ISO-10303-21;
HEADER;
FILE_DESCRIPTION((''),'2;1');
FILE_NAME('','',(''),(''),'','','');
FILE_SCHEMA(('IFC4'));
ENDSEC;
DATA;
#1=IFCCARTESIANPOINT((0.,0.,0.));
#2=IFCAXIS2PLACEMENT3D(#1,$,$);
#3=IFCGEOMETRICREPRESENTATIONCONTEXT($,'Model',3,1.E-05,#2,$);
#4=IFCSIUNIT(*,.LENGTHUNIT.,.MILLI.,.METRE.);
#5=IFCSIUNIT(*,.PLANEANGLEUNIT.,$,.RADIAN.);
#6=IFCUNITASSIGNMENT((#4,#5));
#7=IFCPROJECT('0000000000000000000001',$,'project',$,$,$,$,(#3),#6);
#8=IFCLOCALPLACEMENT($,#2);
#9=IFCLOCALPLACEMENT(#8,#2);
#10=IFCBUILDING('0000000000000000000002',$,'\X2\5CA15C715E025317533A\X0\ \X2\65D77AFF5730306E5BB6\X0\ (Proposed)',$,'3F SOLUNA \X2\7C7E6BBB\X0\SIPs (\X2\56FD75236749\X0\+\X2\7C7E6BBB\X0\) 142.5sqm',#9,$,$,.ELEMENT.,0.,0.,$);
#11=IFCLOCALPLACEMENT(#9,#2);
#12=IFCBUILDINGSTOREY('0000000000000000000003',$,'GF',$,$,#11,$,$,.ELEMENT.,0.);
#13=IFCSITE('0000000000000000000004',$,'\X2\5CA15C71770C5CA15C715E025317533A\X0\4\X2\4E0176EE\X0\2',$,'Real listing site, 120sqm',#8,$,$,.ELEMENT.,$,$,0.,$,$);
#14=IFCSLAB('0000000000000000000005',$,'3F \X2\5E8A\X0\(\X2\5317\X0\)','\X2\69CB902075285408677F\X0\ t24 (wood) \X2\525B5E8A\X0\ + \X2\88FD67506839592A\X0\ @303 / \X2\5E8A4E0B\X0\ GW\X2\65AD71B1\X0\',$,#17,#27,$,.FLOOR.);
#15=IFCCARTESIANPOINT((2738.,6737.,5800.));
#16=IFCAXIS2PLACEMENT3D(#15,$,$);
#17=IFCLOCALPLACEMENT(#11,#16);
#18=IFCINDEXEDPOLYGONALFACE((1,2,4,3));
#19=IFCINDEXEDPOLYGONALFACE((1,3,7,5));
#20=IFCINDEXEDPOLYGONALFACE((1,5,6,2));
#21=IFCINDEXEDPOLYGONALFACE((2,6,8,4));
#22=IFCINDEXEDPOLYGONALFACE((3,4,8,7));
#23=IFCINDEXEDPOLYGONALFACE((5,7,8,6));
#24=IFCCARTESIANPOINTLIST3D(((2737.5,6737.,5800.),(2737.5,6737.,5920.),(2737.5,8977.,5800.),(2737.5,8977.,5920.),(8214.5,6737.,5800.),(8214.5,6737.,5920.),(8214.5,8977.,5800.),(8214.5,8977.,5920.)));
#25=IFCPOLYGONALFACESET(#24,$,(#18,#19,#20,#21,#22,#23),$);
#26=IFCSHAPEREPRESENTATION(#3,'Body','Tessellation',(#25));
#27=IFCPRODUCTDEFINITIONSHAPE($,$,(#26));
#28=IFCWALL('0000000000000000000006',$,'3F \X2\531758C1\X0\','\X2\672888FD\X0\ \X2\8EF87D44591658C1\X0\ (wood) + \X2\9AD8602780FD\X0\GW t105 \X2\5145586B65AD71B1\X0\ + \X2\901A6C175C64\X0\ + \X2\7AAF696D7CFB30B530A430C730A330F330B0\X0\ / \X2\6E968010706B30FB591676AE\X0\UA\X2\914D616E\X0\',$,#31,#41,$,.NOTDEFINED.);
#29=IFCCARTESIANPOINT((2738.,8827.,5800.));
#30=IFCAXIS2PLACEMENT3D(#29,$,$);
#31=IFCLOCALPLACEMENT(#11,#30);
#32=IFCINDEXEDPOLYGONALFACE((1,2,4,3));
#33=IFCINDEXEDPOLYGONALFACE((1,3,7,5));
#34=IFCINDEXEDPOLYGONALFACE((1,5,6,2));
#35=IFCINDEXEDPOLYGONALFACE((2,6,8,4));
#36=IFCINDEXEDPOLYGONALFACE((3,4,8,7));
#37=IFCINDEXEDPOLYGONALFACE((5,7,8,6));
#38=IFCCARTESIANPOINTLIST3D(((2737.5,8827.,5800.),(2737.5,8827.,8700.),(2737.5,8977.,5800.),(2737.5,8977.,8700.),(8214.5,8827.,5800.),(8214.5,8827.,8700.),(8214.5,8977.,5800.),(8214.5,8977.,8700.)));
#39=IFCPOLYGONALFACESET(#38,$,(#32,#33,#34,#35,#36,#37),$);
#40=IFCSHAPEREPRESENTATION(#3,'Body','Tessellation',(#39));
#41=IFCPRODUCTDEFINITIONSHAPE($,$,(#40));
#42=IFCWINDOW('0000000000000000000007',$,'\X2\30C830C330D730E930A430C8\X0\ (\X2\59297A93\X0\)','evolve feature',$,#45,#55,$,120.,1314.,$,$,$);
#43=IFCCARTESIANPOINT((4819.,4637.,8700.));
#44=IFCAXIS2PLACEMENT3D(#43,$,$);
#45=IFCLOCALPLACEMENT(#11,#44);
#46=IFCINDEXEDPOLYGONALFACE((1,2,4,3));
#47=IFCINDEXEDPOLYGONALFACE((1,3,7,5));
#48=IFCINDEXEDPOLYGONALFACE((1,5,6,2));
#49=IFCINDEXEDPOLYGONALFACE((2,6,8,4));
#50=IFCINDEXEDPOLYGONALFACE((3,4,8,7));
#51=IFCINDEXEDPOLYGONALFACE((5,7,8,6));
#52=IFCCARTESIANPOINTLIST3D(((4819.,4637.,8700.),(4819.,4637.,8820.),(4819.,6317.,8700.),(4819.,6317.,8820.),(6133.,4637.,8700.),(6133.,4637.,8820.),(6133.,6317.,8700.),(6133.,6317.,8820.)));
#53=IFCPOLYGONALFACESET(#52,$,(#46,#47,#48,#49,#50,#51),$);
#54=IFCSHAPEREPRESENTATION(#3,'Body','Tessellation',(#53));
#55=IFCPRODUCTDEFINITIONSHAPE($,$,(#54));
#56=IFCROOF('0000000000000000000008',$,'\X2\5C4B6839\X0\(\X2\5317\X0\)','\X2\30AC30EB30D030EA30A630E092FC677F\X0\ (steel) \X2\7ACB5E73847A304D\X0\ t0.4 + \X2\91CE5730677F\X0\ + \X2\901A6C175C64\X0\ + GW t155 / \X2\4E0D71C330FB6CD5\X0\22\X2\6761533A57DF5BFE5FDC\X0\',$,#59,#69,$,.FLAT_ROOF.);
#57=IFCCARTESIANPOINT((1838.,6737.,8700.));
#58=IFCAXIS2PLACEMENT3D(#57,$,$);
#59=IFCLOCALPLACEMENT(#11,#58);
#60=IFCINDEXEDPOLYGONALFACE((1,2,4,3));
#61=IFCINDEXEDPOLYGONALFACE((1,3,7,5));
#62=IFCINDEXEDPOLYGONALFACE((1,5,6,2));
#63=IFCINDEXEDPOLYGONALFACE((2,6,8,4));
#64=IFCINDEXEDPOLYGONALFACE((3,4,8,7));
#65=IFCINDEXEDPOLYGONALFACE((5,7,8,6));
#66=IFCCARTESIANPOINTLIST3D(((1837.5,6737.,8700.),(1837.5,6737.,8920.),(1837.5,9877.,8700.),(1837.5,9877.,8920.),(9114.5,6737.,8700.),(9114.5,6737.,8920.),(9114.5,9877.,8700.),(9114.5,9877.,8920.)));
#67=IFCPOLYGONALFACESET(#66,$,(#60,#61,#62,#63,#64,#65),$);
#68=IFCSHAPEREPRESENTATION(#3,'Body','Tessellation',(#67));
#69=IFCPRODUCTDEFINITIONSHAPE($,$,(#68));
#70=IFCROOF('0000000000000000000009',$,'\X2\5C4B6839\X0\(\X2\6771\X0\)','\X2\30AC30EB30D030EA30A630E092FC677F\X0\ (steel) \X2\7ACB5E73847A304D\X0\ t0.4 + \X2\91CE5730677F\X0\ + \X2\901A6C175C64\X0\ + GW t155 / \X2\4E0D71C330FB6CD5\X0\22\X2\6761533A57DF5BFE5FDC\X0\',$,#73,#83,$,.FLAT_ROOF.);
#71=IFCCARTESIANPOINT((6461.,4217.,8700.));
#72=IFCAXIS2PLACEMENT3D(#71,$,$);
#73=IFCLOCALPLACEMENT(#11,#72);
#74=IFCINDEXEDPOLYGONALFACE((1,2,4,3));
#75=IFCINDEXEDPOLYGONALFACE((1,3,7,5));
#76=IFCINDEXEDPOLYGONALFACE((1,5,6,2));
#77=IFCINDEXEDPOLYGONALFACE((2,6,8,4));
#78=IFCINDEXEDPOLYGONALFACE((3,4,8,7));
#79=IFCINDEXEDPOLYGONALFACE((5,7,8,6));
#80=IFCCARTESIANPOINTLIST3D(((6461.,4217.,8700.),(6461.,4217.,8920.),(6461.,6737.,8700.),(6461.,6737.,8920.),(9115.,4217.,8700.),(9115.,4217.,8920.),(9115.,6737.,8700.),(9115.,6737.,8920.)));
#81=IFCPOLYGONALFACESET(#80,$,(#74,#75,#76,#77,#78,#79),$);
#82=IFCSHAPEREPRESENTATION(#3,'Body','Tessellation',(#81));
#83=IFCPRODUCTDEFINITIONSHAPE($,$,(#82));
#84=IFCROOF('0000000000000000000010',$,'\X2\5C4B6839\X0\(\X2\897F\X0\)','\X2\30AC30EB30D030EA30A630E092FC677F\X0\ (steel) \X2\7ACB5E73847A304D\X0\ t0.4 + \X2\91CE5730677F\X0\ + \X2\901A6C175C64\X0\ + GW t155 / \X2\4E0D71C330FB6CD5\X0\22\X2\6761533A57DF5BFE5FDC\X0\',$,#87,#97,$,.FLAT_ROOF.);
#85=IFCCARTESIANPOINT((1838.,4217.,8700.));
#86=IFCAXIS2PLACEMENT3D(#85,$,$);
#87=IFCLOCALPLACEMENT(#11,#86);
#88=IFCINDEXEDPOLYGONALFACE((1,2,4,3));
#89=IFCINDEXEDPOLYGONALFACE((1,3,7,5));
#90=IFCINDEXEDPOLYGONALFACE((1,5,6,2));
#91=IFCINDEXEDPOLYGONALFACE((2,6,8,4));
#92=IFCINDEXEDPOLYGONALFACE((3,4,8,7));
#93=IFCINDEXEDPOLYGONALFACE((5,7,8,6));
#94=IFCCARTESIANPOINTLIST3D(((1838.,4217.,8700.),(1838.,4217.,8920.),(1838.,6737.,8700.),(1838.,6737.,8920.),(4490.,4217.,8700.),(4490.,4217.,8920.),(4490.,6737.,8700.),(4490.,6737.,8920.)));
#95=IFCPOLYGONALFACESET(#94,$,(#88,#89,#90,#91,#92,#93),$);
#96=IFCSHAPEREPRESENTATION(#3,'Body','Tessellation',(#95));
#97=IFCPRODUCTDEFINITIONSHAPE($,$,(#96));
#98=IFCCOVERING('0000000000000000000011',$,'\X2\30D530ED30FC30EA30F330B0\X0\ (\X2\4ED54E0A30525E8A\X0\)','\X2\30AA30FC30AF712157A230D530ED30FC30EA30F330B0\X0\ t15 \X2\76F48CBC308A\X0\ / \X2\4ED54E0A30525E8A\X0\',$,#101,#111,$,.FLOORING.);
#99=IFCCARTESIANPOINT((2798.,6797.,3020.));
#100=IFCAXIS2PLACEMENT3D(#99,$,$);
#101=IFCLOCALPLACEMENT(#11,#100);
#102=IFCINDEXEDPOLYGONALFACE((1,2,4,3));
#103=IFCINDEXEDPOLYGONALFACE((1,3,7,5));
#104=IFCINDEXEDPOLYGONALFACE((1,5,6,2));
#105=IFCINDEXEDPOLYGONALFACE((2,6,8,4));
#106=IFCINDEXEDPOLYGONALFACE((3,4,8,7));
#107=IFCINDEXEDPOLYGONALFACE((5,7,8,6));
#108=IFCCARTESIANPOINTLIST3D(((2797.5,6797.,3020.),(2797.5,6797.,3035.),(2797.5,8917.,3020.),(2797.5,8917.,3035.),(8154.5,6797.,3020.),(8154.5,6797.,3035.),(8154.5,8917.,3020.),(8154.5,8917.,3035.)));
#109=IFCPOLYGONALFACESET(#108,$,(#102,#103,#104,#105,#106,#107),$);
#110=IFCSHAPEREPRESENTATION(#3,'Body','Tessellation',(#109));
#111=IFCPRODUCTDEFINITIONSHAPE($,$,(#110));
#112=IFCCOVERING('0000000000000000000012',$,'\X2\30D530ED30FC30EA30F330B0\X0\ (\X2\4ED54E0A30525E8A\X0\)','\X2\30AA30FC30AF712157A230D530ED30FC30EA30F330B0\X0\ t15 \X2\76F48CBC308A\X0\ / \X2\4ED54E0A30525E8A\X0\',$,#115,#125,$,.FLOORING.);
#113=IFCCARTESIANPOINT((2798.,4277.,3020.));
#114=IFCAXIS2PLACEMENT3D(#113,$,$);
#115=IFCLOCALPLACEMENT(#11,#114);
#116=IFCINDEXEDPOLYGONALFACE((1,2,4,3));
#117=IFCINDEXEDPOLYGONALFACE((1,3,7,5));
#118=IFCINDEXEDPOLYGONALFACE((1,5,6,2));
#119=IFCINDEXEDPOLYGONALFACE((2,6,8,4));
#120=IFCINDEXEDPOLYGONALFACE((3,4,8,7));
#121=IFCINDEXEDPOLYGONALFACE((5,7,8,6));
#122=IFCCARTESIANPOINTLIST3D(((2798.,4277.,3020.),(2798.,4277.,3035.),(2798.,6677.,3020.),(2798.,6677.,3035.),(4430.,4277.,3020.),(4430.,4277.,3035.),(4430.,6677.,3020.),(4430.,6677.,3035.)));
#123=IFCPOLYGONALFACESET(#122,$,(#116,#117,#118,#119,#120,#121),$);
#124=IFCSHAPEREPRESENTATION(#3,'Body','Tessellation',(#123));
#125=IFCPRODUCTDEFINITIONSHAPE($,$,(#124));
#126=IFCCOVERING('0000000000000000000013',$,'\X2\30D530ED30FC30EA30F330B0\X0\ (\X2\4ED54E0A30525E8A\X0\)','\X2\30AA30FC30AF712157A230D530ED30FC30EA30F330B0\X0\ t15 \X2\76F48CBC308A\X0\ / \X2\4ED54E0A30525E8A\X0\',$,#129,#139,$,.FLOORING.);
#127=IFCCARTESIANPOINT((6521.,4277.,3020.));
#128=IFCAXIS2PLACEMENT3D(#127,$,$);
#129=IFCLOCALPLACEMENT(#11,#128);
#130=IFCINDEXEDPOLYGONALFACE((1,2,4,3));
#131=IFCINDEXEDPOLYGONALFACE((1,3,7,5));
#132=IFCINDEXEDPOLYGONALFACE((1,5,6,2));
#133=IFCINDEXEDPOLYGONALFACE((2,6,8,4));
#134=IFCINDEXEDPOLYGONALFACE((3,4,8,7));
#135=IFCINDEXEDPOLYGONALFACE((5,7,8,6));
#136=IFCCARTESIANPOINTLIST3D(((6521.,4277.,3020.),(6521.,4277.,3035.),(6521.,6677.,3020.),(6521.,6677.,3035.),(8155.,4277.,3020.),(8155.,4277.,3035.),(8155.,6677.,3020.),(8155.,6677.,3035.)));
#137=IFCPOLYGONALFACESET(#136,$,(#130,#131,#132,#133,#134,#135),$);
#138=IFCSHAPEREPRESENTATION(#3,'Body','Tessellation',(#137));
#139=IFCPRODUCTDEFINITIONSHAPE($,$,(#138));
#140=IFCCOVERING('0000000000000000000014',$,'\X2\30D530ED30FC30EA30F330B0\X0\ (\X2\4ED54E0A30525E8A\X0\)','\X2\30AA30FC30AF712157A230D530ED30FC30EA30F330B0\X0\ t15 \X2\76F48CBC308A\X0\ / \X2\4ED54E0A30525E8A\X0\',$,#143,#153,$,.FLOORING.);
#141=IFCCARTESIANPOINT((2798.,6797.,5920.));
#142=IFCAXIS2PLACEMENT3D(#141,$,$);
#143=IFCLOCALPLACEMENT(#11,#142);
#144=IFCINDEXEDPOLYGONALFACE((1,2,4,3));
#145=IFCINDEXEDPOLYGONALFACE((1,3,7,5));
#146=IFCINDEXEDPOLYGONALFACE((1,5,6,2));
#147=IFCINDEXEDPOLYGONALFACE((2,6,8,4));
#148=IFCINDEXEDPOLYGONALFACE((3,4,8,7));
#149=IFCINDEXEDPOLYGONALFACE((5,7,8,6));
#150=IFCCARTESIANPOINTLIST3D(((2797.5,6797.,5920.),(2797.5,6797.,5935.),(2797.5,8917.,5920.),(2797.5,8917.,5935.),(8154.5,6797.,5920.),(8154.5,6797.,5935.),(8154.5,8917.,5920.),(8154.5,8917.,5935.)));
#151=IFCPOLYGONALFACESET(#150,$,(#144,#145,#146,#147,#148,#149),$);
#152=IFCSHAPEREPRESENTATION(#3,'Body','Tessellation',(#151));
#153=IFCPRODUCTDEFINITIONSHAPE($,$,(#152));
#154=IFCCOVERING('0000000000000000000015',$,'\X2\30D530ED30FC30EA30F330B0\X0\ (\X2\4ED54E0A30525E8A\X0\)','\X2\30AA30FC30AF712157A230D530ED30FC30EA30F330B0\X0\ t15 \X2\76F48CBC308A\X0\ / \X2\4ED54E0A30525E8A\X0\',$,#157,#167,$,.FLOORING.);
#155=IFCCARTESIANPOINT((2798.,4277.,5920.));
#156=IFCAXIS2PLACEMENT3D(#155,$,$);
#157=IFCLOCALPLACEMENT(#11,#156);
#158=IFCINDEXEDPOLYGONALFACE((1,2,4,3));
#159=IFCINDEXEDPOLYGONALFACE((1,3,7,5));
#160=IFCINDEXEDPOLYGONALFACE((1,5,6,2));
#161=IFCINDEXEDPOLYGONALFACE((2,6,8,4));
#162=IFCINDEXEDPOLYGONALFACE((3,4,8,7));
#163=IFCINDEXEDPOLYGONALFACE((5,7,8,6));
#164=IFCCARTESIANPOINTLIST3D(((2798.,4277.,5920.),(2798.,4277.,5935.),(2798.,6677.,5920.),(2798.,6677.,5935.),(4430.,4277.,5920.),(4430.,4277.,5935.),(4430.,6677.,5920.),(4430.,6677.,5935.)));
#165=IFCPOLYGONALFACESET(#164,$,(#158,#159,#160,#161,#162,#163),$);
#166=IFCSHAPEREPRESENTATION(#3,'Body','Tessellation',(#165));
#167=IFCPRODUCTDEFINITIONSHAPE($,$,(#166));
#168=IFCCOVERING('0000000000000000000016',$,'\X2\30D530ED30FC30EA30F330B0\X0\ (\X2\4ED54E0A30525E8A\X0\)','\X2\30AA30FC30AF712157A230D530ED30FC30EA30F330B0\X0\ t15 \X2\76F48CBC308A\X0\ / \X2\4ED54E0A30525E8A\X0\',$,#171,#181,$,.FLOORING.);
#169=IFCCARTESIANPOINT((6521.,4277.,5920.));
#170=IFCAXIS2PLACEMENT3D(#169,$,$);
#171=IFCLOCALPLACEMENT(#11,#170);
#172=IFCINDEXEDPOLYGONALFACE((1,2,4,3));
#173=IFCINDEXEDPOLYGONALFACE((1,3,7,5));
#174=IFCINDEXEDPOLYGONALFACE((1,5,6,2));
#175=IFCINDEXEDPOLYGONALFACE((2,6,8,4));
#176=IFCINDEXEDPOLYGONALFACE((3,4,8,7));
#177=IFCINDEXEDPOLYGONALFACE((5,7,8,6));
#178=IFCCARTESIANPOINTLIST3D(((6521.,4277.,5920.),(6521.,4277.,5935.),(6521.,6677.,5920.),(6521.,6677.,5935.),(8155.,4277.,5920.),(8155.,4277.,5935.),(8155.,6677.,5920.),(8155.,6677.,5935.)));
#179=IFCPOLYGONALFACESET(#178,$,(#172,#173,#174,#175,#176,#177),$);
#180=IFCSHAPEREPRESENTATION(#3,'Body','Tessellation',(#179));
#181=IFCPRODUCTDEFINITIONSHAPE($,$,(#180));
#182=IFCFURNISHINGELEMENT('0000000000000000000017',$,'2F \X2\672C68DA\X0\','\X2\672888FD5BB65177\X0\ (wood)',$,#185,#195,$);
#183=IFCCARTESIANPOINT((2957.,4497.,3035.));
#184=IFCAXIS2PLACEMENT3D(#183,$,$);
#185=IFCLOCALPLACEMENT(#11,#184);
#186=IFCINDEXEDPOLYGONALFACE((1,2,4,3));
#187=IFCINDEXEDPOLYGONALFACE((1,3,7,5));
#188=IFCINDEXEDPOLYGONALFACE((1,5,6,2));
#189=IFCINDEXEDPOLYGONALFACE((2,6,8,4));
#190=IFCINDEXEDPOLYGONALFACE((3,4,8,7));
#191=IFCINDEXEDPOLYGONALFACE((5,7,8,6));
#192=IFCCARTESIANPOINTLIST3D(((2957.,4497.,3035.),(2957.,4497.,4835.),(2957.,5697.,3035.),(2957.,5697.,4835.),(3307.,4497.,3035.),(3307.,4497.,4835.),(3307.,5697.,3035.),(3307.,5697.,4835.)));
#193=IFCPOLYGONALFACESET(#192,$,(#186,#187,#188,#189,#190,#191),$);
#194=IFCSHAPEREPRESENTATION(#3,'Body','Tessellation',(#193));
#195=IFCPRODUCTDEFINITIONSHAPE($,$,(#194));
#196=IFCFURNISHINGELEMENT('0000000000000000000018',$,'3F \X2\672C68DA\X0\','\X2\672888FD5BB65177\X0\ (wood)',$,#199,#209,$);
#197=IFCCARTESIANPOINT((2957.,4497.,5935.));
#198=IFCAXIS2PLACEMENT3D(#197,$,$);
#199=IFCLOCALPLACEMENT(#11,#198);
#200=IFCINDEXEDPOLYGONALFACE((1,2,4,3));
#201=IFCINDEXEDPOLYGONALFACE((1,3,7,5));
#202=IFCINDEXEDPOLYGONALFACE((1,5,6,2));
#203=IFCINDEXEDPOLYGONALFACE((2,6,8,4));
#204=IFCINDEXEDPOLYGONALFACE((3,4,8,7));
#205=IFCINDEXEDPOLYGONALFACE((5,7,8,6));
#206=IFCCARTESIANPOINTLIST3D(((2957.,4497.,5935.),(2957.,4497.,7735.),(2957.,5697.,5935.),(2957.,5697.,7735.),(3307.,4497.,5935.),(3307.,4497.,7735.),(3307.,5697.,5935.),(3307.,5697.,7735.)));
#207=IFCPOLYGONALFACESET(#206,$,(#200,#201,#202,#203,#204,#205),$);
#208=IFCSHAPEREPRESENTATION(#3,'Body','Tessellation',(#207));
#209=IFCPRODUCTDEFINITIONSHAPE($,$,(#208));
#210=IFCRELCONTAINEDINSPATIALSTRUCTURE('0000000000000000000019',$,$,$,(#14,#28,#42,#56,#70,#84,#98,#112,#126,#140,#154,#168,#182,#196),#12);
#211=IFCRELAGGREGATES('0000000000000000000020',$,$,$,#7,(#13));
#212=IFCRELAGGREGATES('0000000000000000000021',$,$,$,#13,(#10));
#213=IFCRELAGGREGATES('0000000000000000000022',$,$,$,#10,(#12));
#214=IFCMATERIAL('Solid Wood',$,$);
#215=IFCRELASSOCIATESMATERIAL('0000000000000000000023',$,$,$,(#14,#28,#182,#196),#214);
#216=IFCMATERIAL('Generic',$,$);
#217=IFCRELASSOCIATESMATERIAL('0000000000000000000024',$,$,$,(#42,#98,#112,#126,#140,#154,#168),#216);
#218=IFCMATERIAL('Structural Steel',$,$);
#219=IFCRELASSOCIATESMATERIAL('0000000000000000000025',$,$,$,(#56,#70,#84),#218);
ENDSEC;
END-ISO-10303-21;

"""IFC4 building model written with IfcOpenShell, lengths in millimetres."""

from ifc_helpers import new_model, si_unit, frame, frame_2d, origin, place, context, project, spatial, rectangle, extrude, material, element, save


model = new_model("IFC4")

# Units and contexts
model_context = context("Model", 3, precision=1e-05, world=origin())
ifc_project = project(units=[si_unit("LENGTHUNIT", "METRE", prefix="MILLI"), si_unit("PLANEANGLEUNIT", "RADIAN")], contexts=[model_context])

# Site, building, storey
site_placement = place(None, origin())
site = spatial("IfcSite", under=ifc_project, at=site_placement, Name="岡山県岡山市北区4丁目2", ObjectType="Real listing site, 120sqm", CompositionType="ELEMENT", RefElevation=0.0)
building_placement = place(site_placement, origin())
building = spatial("IfcBuilding", under=site, at=building_placement, Name="岡山市北区 旗竿地の家 (Proposed)", ObjectType="3F SOLUNA 籾殻SIPs (国産杉+籾殻) 142.5sqm", CompositionType="ELEMENT", ElevationOfRefHeight=0.0, ElevationOfTerrain=0.0)
storey_placement = place(building_placement, origin())
storey = spatial("IfcBuildingStorey", under=building, at=storey_placement, Name="GF", CompositionType="ELEMENT", Elevation=0.0)

# Slab
ifc_material_1 = material(Name="Solid Wood")
slab_placement = place(storey_placement, frame((2738.0, 6737.0, 5800.0)))
element("IfcSlab", 1, at=slab_placement, inside=storey, material=ifc_material_1, Name="3F 床(北)", Description="構造用合板 t24 (wood) 剛床 + 製材根太 @303 / 床下 GW断熱", PredefinedType="FLOOR", context=model_context, shape_type="SweptSolid", body=[
    extrude(rectangle(XDim=5477.0, YDim=2240.0, at=frame_2d((2738.0, 1120.0))), frame((2738.0, 6737.0, 5800.0)), (0.0, 0.0, 1.0), 120.0),
])

# Wall
wall_1_placement = place(storey_placement, frame((2738.0, 8827.0, 5800.0)))
element("IfcWall", 2, at=wall_1_placement, inside=storey, material=ifc_material_1, Name="3F 北壁", Description="木製 軸組外壁 (wood) + 高性能GW t105 充填断熱 + 通気層 + 窯業系サイディング / 準耐火・外皮UA配慮", PredefinedType="NOTDEFINED", context=model_context, shape_type="SweptSolid", body=[
    extrude(rectangle(XDim=5477.0, YDim=150.0, at=frame_2d((2738.0, 75.0))), frame((2738.0, 8827.0, 5800.0)), (0.0, 0.0, 1.0), 2900.0),
])

# Window
ifc_material_2 = material(Name="Generic")
window_1_placement = place(storey_placement, frame((4819.0, 4637.0, 8700.0)))
element("IfcWindow", 3, at=window_1_placement, inside=storey, material=ifc_material_2, Name="トップライト (天窓)", Description="evolve feature", OverallHeight=120.0, OverallWidth=1314.0, context=model_context, shape_type="SweptSolid", body=[
    extrude(rectangle(XDim=1314.0, YDim=1680.0, at=frame_2d((657.0, 840.0))), frame((4819.0, 4637.0, 8700.0)), (0.0, 0.0, 1.0), 120.0),
])

# Roofs
ifc_material_3 = material(Name="Structural Steel")
roof_1_placement = place(storey_placement, frame((1838.0, 6737.0, 8700.0)))
element("IfcRoof", 4, at=roof_1_placement, inside=storey, material=ifc_material_3, Name="屋根(北)", Description="ガルバリウム鋼板 (steel) 立平葺き t0.4 + 野地板 + 通気層 + GW t155 / 不燃・法22条区域対応", PredefinedType="FLAT_ROOF", context=model_context, shape_type="SweptSolid", body=[
    extrude(rectangle(XDim=7277.0, YDim=3140.0, at=frame_2d((3638.0, 1570.0))), frame((1838.0, 6737.0, 8700.0)), (0.0, 0.0, 1.0), 220.0),
])
roof_2_placement = place(storey_placement, frame((6461.0, 4217.0, 8700.0)))
element("IfcRoof", 5, at=roof_2_placement, inside=storey, material=ifc_material_3, Name="屋根(東)", Description="ガルバリウム鋼板 (steel) 立平葺き t0.4 + 野地板 + 通気層 + GW t155 / 不燃・法22条区域対応", PredefinedType="FLAT_ROOF", context=model_context, shape_type="SweptSolid", body=[
    extrude(rectangle(XDim=2654.0, YDim=2520.0, at=frame_2d((1327.0, 1260.0))), frame((6461.0, 4217.0, 8700.0)), (0.0, 0.0, 1.0), 220.0),
])
roof_3_placement = place(storey_placement, frame((1838.0, 4217.0, 8700.0)))
element("IfcRoof", 6, at=roof_3_placement, inside=storey, material=ifc_material_3, Name="屋根(西)", Description="ガルバリウム鋼板 (steel) 立平葺き t0.4 + 野地板 + 通気層 + GW t155 / 不燃・法22条区域対応", PredefinedType="FLAT_ROOF", context=model_context, shape_type="SweptSolid", body=[
    extrude(rectangle(XDim=2652.0, YDim=2520.0, at=frame_2d((1326.0, 1260.0))), frame((1838.0, 4217.0, 8700.0)), (0.0, 0.0, 1.0), 220.0),
])

# Coverings
covering_1_placement = place(storey_placement, frame((2798.0, 6797.0, 3020.0)))
element("IfcCovering", 7, at=covering_1_placement, inside=storey, material=ifc_material_2, Name="フローリング (仕上げ床)", Description="オーク無垢フローリング t15 直貼り / 仕上げ床", PredefinedType="FLOORING", context=model_context, shape_type="SweptSolid", body=[
    extrude(rectangle(XDim=5357.0, YDim=2120.0, at=frame_2d((2678.0, 1060.0))), frame((2798.0, 6797.0, 3020.0)), (0.0, 0.0, 1.0), 15.0),
])
covering_2_placement = place(storey_placement, frame((2798.0, 4277.0, 3020.0)))
element("IfcCovering", 8, at=covering_2_placement, inside=storey, material=ifc_material_2, Name="フローリング (仕上げ床)", Description="オーク無垢フローリング t15 直貼り / 仕上げ床", PredefinedType="FLOORING", context=model_context, shape_type="SweptSolid", body=[
    extrude(rectangle(XDim=1632.0, YDim=2400.0, at=frame_2d((816.0, 1200.0))), frame((2798.0, 4277.0, 3020.0)), (0.0, 0.0, 1.0), 15.0),
])
covering_3_placement = place(storey_placement, frame((6521.0, 4277.0, 3020.0)))
element("IfcCovering", 9, at=covering_3_placement, inside=storey, material=ifc_material_2, Name="フローリング (仕上げ床)", Description="オーク無垢フローリング t15 直貼り / 仕上げ床", PredefinedType="FLOORING", context=model_context, shape_type="SweptSolid", body=[
    extrude(rectangle(XDim=1634.0, YDim=2400.0, at=frame_2d((817.0, 1200.0))), frame((6521.0, 4277.0, 3020.0)), (0.0, 0.0, 1.0), 15.0),
])
covering_4_placement = place(storey_placement, frame((2798.0, 6797.0, 5920.0)))
element("IfcCovering", 10, at=covering_4_placement, inside=storey, material=ifc_material_2, Name="フローリング (仕上げ床)", Description="オーク無垢フローリング t15 直貼り / 仕上げ床", PredefinedType="FLOORING", context=model_context, shape_type="SweptSolid", body=[
    extrude(rectangle(XDim=5357.0, YDim=2120.0, at=frame_2d((2678.0, 1060.0))), frame((2798.0, 6797.0, 5920.0)), (0.0, 0.0, 1.0), 15.0),
])
covering_5_placement = place(storey_placement, frame((2798.0, 4277.0, 5920.0)))
element("IfcCovering", 11, at=covering_5_placement, inside=storey, material=ifc_material_2, Name="フローリング (仕上げ床)", Description="オーク無垢フローリング t15 直貼り / 仕上げ床", PredefinedType="FLOORING", context=model_context, shape_type="SweptSolid", body=[
    extrude(rectangle(XDim=1632.0, YDim=2400.0, at=frame_2d((816.0, 1200.0))), frame((2798.0, 4277.0, 5920.0)), (0.0, 0.0, 1.0), 15.0),
])
covering_6_placement = place(storey_placement, frame((6521.0, 4277.0, 5920.0)))
element("IfcCovering", 12, at=covering_6_placement, inside=storey, material=ifc_material_2, Name="フローリング (仕上げ床)", Description="オーク無垢フローリング t15 直貼り / 仕上げ床", PredefinedType="FLOORING", context=model_context, shape_type="SweptSolid", body=[
    extrude(rectangle(XDim=1634.0, YDim=2400.0, at=frame_2d((817.0, 1200.0))), frame((6521.0, 4277.0, 5920.0)), (0.0, 0.0, 1.0), 15.0),
])

# Furnishing elements
furnishing_1_placement = place(storey_placement, frame((2957.0, 4497.0, 3035.0)))
element("IfcFurnishingElement", 13, at=furnishing_1_placement, inside=storey, material=ifc_material_1, Name="2F 本棚", Description="木製家具 (wood)", context=model_context, shape_type="SweptSolid", body=[
    extrude(rectangle(XDim=350.0, YDim=1200.0, at=frame_2d((175.0, 600.0))), frame((2957.0, 4497.0, 3035.0)), (0.0, 0.0, 1.0), 1800.0),
])
furnishing_2_placement = place(storey_placement, frame((2957.0, 4497.0, 5935.0)))
element("IfcFurnishingElement", 14, at=furnishing_2_placement, inside=storey, material=ifc_material_1, Name="3F 本棚", Description="木製家具 (wood)", context=model_context, shape_type="SweptSolid", body=[
    extrude(rectangle(XDim=350.0, YDim=1200.0, at=frame_2d((175.0, 600.0))), frame((2957.0, 4497.0, 5935.0)), (0.0, 0.0, 1.0), 1800.0),
])

save(model, "model.ifc")
